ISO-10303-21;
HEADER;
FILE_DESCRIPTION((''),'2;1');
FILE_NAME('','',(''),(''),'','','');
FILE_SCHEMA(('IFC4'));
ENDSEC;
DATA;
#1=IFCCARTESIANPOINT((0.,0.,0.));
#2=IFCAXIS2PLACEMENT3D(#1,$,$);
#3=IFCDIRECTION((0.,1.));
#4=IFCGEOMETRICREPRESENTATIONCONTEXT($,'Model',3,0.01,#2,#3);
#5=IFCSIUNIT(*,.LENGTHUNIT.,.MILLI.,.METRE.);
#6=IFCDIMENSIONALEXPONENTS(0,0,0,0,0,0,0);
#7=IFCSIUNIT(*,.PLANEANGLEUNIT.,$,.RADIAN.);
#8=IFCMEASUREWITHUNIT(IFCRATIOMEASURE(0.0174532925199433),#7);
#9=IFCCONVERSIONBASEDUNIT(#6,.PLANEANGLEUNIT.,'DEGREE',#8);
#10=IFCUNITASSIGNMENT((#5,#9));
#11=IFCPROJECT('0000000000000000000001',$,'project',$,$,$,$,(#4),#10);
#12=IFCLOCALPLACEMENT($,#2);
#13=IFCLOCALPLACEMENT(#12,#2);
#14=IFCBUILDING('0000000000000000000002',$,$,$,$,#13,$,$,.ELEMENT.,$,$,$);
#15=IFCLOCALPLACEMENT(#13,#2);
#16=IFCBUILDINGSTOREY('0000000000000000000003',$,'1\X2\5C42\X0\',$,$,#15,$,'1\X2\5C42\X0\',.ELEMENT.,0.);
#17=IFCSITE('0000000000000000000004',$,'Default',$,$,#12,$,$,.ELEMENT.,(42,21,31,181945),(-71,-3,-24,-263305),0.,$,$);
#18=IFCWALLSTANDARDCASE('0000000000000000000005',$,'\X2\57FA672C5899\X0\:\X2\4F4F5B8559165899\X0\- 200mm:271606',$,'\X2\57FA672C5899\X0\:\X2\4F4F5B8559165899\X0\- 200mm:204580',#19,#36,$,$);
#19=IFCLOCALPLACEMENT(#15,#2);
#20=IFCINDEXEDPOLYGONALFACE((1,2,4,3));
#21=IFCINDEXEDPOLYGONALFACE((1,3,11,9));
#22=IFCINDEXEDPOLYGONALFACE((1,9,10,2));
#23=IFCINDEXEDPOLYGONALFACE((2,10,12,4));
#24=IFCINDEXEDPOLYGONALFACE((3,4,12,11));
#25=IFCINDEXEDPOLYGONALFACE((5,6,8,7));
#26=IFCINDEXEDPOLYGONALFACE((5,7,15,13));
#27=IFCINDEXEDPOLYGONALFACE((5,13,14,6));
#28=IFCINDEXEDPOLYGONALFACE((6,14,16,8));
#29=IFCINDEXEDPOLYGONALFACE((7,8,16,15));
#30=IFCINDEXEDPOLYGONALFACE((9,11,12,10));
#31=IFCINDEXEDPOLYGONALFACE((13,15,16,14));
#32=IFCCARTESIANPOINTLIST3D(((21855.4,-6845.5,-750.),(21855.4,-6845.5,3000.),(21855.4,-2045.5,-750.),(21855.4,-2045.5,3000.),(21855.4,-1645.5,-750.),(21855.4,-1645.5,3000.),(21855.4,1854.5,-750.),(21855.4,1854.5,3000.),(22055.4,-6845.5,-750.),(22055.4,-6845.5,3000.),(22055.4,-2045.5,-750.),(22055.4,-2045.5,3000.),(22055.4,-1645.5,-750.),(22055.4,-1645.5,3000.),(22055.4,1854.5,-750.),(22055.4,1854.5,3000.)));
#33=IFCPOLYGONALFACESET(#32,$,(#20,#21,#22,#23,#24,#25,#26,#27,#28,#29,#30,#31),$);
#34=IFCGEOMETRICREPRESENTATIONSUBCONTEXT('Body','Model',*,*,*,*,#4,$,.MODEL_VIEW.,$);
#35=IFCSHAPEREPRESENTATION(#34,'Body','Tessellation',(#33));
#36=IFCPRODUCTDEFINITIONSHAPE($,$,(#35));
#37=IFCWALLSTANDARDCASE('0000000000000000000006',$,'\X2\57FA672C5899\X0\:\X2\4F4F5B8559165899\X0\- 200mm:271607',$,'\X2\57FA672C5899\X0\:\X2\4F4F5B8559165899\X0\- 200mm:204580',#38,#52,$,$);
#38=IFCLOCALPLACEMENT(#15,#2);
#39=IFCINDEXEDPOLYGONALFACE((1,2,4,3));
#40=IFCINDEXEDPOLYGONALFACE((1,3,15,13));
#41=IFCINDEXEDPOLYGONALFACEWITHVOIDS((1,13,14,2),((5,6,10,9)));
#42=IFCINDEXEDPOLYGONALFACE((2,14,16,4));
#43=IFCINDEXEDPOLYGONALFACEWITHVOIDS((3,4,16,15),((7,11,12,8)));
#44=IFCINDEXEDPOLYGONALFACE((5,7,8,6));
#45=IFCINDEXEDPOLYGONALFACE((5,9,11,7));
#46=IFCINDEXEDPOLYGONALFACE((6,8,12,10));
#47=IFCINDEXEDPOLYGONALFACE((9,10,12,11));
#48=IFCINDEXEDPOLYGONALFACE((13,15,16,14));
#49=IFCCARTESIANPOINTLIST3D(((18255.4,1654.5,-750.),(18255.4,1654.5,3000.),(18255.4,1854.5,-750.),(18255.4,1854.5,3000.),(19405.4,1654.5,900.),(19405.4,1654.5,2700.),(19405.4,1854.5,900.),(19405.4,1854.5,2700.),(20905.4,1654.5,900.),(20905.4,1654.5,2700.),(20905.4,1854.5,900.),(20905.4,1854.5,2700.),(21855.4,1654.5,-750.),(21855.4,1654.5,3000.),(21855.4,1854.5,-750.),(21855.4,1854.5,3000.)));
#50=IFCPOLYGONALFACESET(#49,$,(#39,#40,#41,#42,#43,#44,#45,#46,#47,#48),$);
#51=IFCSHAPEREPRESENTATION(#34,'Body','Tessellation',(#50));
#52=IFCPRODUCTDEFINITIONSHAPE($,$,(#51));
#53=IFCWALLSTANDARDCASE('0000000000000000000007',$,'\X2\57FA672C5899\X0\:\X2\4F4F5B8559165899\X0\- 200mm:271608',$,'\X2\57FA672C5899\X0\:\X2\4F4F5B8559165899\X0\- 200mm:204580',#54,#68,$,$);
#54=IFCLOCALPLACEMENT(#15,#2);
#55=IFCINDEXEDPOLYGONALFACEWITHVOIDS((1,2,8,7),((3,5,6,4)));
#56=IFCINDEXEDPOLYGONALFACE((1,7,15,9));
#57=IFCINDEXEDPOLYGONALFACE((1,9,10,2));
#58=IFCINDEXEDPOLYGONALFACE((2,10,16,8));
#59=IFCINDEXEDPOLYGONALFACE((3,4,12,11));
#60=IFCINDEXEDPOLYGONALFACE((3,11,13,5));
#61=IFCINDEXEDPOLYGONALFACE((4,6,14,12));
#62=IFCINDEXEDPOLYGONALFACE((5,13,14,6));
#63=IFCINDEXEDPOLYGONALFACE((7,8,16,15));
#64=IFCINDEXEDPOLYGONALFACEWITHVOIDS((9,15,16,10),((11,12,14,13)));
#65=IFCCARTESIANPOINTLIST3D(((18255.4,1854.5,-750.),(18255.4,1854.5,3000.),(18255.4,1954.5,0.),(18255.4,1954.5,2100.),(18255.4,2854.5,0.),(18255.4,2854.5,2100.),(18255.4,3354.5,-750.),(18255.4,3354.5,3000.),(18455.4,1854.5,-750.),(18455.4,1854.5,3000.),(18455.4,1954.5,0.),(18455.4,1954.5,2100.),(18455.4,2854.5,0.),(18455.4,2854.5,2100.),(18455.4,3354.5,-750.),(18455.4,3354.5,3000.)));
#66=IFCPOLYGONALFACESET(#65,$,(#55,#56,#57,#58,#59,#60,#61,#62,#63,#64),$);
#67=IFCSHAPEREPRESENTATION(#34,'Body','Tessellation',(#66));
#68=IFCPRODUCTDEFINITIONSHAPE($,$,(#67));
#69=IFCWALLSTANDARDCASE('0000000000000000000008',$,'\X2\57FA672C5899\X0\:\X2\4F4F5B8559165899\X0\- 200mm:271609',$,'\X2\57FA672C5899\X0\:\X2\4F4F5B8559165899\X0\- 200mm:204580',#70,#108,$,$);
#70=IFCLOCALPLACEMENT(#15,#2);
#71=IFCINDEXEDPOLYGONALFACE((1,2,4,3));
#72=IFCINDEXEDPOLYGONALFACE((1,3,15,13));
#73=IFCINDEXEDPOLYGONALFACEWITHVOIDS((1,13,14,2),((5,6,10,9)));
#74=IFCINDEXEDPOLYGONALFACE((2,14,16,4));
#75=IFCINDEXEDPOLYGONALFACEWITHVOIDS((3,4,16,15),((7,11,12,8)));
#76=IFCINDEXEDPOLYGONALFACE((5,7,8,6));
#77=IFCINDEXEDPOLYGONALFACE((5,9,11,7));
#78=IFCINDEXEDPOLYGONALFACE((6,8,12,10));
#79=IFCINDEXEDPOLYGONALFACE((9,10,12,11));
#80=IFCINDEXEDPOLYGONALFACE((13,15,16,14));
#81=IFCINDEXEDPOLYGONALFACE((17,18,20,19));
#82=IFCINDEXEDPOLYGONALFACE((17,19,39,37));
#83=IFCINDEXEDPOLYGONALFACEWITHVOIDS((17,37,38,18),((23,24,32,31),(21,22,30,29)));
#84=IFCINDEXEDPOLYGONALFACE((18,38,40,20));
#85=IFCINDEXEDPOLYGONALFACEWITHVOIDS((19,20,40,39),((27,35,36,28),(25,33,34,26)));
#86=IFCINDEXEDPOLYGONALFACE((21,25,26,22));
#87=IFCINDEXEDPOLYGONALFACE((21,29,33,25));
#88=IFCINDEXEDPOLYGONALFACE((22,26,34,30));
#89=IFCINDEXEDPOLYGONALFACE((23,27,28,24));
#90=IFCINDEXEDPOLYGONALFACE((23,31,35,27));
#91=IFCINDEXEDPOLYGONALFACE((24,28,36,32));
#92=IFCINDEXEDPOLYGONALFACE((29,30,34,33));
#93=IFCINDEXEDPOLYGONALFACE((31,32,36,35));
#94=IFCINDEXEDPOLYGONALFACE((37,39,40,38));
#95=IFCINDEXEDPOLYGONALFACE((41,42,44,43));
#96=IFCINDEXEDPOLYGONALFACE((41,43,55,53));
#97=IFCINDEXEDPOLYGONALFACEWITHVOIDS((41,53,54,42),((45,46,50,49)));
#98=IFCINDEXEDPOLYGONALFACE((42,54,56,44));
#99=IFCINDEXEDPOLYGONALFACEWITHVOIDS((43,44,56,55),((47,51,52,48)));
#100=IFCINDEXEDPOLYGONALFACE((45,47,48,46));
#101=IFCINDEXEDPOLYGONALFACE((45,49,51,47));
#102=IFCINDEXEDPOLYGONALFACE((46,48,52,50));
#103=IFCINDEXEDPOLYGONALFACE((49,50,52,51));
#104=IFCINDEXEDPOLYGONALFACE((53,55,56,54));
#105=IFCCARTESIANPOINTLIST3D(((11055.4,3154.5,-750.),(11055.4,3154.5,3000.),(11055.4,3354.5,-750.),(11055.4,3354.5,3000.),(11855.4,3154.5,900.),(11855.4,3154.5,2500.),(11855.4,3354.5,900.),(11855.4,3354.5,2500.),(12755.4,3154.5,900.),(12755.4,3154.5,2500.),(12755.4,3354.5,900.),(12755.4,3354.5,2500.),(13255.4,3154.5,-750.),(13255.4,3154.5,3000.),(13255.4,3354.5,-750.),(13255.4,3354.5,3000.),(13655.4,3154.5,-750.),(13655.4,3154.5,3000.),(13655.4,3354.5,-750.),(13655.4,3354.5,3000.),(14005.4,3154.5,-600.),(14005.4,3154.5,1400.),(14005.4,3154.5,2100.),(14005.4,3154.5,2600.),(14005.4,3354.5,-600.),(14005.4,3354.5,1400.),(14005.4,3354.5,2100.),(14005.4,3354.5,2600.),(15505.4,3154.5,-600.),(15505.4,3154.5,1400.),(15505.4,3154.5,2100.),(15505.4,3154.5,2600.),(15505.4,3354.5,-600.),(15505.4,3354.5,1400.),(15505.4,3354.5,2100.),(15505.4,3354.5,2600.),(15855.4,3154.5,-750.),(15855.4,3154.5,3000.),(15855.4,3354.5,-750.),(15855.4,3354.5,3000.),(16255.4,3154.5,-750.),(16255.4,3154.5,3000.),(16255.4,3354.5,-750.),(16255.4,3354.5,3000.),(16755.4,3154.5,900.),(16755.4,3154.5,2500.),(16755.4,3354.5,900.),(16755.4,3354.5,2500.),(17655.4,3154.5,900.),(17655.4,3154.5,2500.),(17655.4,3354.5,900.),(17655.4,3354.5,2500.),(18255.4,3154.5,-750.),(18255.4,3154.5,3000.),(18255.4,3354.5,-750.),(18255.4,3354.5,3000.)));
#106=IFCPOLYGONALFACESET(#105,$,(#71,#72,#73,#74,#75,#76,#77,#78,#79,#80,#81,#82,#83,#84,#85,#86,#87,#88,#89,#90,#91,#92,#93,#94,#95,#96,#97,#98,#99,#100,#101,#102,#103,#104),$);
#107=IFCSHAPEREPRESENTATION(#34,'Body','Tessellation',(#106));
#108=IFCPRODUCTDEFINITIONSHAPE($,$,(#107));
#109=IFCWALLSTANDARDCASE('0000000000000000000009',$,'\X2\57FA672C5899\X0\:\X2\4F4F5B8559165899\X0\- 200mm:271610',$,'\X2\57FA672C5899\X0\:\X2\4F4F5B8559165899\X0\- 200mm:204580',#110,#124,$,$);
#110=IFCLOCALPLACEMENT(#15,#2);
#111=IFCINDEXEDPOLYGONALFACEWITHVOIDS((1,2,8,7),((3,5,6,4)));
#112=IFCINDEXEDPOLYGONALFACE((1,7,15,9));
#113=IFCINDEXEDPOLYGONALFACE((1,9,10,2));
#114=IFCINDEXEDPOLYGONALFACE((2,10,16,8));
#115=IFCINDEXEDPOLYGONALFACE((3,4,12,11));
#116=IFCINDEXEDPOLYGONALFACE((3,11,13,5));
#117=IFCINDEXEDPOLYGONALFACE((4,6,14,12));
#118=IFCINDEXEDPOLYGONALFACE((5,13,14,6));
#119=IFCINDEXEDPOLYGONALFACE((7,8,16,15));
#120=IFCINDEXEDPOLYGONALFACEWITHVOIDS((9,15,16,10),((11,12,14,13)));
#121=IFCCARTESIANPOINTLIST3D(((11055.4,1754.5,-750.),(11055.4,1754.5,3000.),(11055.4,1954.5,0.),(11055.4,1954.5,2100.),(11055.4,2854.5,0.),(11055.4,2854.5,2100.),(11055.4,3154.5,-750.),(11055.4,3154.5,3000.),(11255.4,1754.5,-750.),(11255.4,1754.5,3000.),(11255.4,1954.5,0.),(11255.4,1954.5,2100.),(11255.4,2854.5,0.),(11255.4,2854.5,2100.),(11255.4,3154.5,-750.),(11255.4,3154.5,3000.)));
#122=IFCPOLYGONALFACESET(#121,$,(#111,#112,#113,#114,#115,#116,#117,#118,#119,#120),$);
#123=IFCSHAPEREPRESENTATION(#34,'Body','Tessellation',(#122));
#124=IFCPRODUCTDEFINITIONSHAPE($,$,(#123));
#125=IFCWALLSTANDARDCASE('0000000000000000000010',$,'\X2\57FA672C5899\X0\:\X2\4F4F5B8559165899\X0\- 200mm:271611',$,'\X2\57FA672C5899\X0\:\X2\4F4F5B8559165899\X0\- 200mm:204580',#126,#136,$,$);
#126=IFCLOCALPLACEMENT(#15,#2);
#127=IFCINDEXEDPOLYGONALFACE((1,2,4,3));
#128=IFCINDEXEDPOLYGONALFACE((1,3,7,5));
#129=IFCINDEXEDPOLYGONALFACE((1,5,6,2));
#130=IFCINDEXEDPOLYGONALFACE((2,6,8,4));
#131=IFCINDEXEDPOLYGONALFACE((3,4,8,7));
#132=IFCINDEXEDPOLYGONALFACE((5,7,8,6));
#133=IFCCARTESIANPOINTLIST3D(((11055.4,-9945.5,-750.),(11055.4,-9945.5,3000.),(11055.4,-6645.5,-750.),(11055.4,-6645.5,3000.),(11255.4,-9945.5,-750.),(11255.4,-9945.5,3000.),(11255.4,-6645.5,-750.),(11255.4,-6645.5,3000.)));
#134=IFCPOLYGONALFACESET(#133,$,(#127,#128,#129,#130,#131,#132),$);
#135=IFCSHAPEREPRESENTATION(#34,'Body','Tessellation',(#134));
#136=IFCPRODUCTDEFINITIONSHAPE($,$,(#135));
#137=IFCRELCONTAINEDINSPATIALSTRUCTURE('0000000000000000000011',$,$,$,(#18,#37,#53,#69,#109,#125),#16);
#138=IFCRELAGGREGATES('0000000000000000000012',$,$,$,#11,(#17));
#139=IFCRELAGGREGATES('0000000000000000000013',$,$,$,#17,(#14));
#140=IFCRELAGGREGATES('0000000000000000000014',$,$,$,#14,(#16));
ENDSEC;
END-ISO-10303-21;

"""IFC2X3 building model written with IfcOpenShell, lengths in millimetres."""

from ifc_helpers import new_model, entity, si_unit, converted_unit, direction, frame, frame_2d, origin, origin_2d_with_axis, place, context, subcontext, project, spatial, polyline, rectangle, extrude, clip, bounded_halfspace, element, save


model = new_model("IFC2X3")

# Units and contexts
model_context = context("Model", 3, precision=0.01, world=origin(), true_north=direction((0.0, 1.0)))
body_context = subcontext(model_context, "Body", "Model", "MODEL_VIEW")
ifc_project = project(units=[si_unit("LENGTHUNIT", "METRE", prefix="MILLI"), converted_unit("PLANEANGLEUNIT", "DEGREE", entity("IfcRatioMeasure", 0.0174532925199433), si_unit("PLANEANGLEUNIT", "RADIAN"), dimensions=[0, 0, 0, 0, 0, 0, 0])], contexts=[model_context])

# Site, building, storey
site_placement = place(None, origin())
site = spatial("IfcSite", under=ifc_project, at=site_placement, Name="Default", CompositionType="ELEMENT", RefLatitude=(42, 21, 31, 181945), RefLongitude=(-71, -3, -24, -263305), RefElevation=0.0)
building_placement = place(site_placement, origin())
building = spatial("IfcBuilding", under=site, at=building_placement, CompositionType="ELEMENT")
storey_placement = place(building_placement, origin())
storey = spatial("IfcBuildingStorey", under=building, at=storey_placement, Name="1层", LongName="1层", CompositionType="ELEMENT", Elevation=0.0)

# Walls, openings
wall_1_placement = place(storey_placement, frame((21955.4, -6845.5, -750.0), z_axis=(0.0, 0.0, 1.0), x_axis=(0.0, 1.0, 0.0)))
wall_1 = element("IfcWallStandardCase", 1, at=wall_1_placement, inside=storey, Name="基本墙:住宅外墙- 200mm:271606", ObjectType="基本墙:住宅外墙- 200mm:204580", context=body_context, shape_type="SweptSolid", body=[
    extrude(rectangle(XDim=8700.0, YDim=200.0, at=frame_2d((4350.0, 0.0), x_axis=(-1.0, 0.0))), origin(), (0.0, 0.0, 1.0), 3750.0),
])
opening_1_placement = place(storey_placement, frame((21955.4, -6845.5, -750.0), z_axis=(0.0, 0.0, 1.0), x_axis=(0.0, 1.0, 0.0)))
element("IfcOpeningElement", 2, at=opening_1_placement, cuts=wall_1, ObjectType="Opening", context=body_context, shape_type="SweptSolid", body=[
    extrude(rectangle(XDim=3750.0, YDim=200.0, at=origin_2d_with_axis()), frame((4800.0, 0.0, 1875.0), z_axis=(1.0, 0.0, 0.0), x_axis=(0.0, 0.0, -1.0)), (0.0, 0.0, 1.0), 400.0),
])
wall_2_placement = place(storey_placement, frame((21855.4, 1754.5, -750.0), z_axis=(0.0, 0.0, 1.0), x_axis=(-1.0, 0.0, 0.0)))
wall_2 = element("IfcWallStandardCase", 3, at=wall_2_placement, inside=storey, Name="基本墙:住宅外墙- 200mm:271607", ObjectType="基本墙:住宅外墙- 200mm:204580", context=body_context, shape_type="SweptSolid", body=[
    extrude(rectangle(XDim=3600.0, YDim=200.0, at=frame_2d((1800.0, 0.0), x_axis=(-1.0, 0.0))), origin(), (0.0, 0.0, 1.0), 3750.0),
])
opening_2_placement = place(wall_2_placement, frame((950.0, -100.0, 1650.0)))
element("IfcOpeningElement", 4, at=opening_2_placement, cuts=wall_2, ObjectType="Opening", context=body_context, shape_type="SweptSolid", body=[
    extrude(rectangle(XDim=1800.0, YDim=1500.0, at=frame_2d((900.0, 750.0), x_axis=(1.0, 0.0))), frame((0.0, 0.0, 0.0), z_axis=(0.0, 1.0, 0.0), x_axis=(0.0, 0.0, 1.0)), (0.0, 0.0, 1.0), 200.0),
])

# Walls, openings
wall_3_placement = place(storey_placement, frame((18355.4, 1854.5, -750.0), z_axis=(0.0, 0.0, 1.0), x_axis=(0.0, 1.0, 0.0)))
wall_3 = element("IfcWallStandardCase", 5, at=wall_3_placement, inside=storey, Name="基本墙:住宅外墙- 200mm:271608", ObjectType="基本墙:住宅外墙- 200mm:204580", context=body_context, shape_type="SweptSolid", body=[
    extrude(rectangle(XDim=1500.0, YDim=200.0, at=frame_2d((750.0, 0.0), x_axis=(-1.0, 0.0))), origin(), (0.0, 0.0, 1.0), 3750.0),
])
opening_3_placement = place(wall_3_placement, frame((1000.0, 100.0, 750.0)))
element("IfcOpeningElement", 6, at=opening_3_placement, cuts=wall_3, ObjectType="Opening", context=body_context, shape_type="SweptSolid", body=[
    extrude(rectangle(XDim=2100.0, YDim=900.0, at=frame_2d((1050.0, 450.0), x_axis=(1.0, 0.0))), frame((0.0, 0.0, 0.0), z_axis=(0.0, -1.0, 0.0), x_axis=(0.0, 0.0, 1.0)), (0.0, 0.0, 1.0), 200.0),
])
opening_4_placement = place(wall_3_placement, origin())
element("IfcOpeningElement", 7, at=opening_4_placement, cuts=wall_3, ObjectType="Opening", context=body_context, shape_type="SweptSolid", body=[
    extrude(rectangle(XDim=2100.0, YDim=900.0, at=frame_2d((0.0, 0.0), x_axis=(1.0, 0.0))), frame((550.0, -1424.0, 4800.0), z_axis=(0.0, 1.0, 0.0), x_axis=(0.0, 0.0, 1.0)), (0.0, 0.0, 1.0), 3048.0),
])
wall_4_placement = place(storey_placement, frame((18255.4, 3254.5, -750.0), z_axis=(0.0, 0.0, 1.0), x_axis=(-1.0, 0.0, 0.0)))
wall_4 = element("IfcWallStandardCase", 8, at=wall_4_placement, inside=storey, Name="基本墙:住宅外墙- 200mm:271609", ObjectType="基本墙:住宅外墙- 200mm:204580", context=body_context, shape_type="SweptSolid", body=[
    extrude(rectangle(XDim=7200.0, YDim=200.0, at=frame_2d((3600.0, 0.0), x_axis=(-1.0, 0.0))), origin(), (0.0, 0.0, 1.0), 3750.0),
])
opening_5_placement = place(wall_4_placement, frame((4250.0, 100.0, 150.0)))
element("IfcOpeningElement", 9, at=opening_5_placement, cuts=wall_4, ObjectType="Opening", context=body_context, shape_type="SweptSolid", body=[
    extrude(rectangle(XDim=2000.0, YDim=1500.0, at=frame_2d((1000.0, 750.0), x_axis=(1.0, 0.0))), frame((0.0, 0.0, 0.0), z_axis=(0.0, -1.0, 0.0), x_axis=(0.0, 0.0, 1.0)), (0.0, 0.0, 1.0), 200.0),
])
opening_6_placement = place(wall_4_placement, frame((4250.0, 100.0, 2850.0)))
element("IfcOpeningElement", 10, at=opening_6_placement, cuts=wall_4, ObjectType="Opening", context=body_context, shape_type="SweptSolid", body=[
    extrude(rectangle(XDim=500.0, YDim=1500.0, at=frame_2d((250.0, 750.0), x_axis=(1.0, 0.0))), frame((0.0, 0.0, 0.0), z_axis=(0.0, -1.0, 0.0), x_axis=(0.0, 0.0, 1.0)), (0.0, 0.0, 1.0), 200.0),
])
opening_7_placement = place(wall_4_placement, frame((5500.0, -100.0, 1650.0)))
element("IfcOpeningElement", 11, at=opening_7_placement, cuts=wall_4, ObjectType="Opening", context=body_context, shape_type="SweptSolid", body=[
    extrude(rectangle(XDim=1600.0, YDim=900.0, at=frame_2d((800.0, 450.0), x_axis=(1.0, 0.0))), frame((0.0, 0.0, 0.0), z_axis=(0.0, 1.0, 0.0), x_axis=(0.0, 0.0, 1.0)), (0.0, 0.0, 1.0), 200.0),
])
opening_8_placement = place(wall_4_placement, frame((600.0, -100.0, 1650.0)))
element("IfcOpeningElement", 12, at=opening_8_placement, cuts=wall_4, ObjectType="Opening", context=body_context, shape_type="SweptSolid", body=[
    extrude(rectangle(XDim=1600.0, YDim=900.0, at=frame_2d((800.0, 450.0), x_axis=(1.0, 0.0))), frame((0.0, 0.0, 0.0), z_axis=(0.0, 1.0, 0.0), x_axis=(0.0, 0.0, 1.0)), (0.0, 0.0, 1.0), 200.0),
])
opening_9_placement = place(storey_placement, frame((18255.4, 3254.5, -750.0), z_axis=(0.0, 0.0, 1.0), x_axis=(-1.0, 0.0, 0.0)))
element("IfcOpeningElement", 13, at=opening_9_placement, cuts=wall_4, ObjectType="Opening", context=body_context, shape_type="SweptSolid", body=[
    extrude(rectangle(XDim=3750.0, YDim=200.0, at=frame_2d((0.0, 0.0), x_axis=(1.0, 0.0))), frame((5000.0, 0.0, 1875.0), z_axis=(-1.0, 0.0, 0.0), x_axis=(0.0, 0.0, 1.0)), (0.0, 0.0, 1.0), 400.0),
])
opening_10_placement = place(storey_placement, frame((18255.4, 3254.5, -750.0), z_axis=(0.0, 0.0, 1.0), x_axis=(-1.0, 0.0, 0.0)))
element("IfcOpeningElement", 14, at=opening_10_placement, cuts=wall_4, ObjectType="Opening", context=body_context, shape_type="SweptSolid", body=[
    extrude(rectangle(XDim=3750.0, YDim=200.0, at=origin_2d_with_axis()), frame((2400.0, 0.0, 1875.0), z_axis=(-1.0, 0.0, 0.0), x_axis=(0.0, 0.0, 1.0)), (0.0, 0.0, 1.0), 400.0),
])
wall_5_placement = place(storey_placement, frame((11155.4, 3154.5, -750.0), z_axis=(0.0, 0.0, 1.0), x_axis=(0.0, -1.0, 0.0)))
wall_5 = element("IfcWallStandardCase", 15, at=wall_5_placement, inside=storey, Name="基本墙:住宅外墙- 200mm:271610", ObjectType="基本墙:住宅外墙- 200mm:204580", context=body_context, shape_type="SweptSolid", body=[
    extrude(rectangle(XDim=1400.0, YDim=200.0, at=frame_2d((700.0, 0.0), x_axis=(-1.0, 0.0))), origin(), (0.0, 0.0, 1.0), 3750.0),
])
opening_11_placement = place(wall_5_placement, frame((1200.0, 100.0, 750.0)))
element("IfcOpeningElement", 16, at=opening_11_placement, cuts=wall_5, ObjectType="Opening", context=body_context, shape_type="SweptSolid", body=[
    extrude(rectangle(XDim=2100.0, YDim=900.0, at=frame_2d((1050.0, 450.0), x_axis=(1.0, 0.0))), frame((0.0, 0.0, 0.0), z_axis=(0.0, -1.0, 0.0), x_axis=(0.0, 0.0, 1.0)), (0.0, 0.0, 1.0), 200.0),
])
opening_12_placement = place(wall_5_placement, origin())
element("IfcOpeningElement", 17, at=opening_12_placement, cuts=wall_5, ObjectType="Opening", context=body_context, shape_type="SweptSolid", body=[
    extrude(rectangle(XDim=2100.0, YDim=900.0, at=frame_2d((0.0, 0.0), x_axis=(0.0, 1.0))), frame((750.0, -1424.0, 4800.0), z_axis=(0.0, 1.0, 0.0), x_axis=(-1.0, 0.0, 0.0)), (0.0, 0.0, 1.0), 3048.0),
])

# Wall
wall_6_placement = place(storey_placement, frame((11155.4, -6645.5, -750.0), z_axis=(0.0, 0.0, 1.0), x_axis=(0.0, -1.0, 0.0)))
element("IfcWallStandardCase", 18, at=wall_6_placement, inside=storey, Name="基本墙:住宅外墙- 200mm:271611", ObjectType="基本墙:住宅外墙- 200mm:204580", context=body_context, shape_type="Clipping", body=[
    clip(extrude(rectangle(XDim=3300.0, YDim=200.0, at=frame_2d((1650.0, 0.0), x_axis=(-1.0, 0.0))), origin(), (0.0, 0.0, 1.0), 3750.0), bounded_halfspace(frame((3300.0, -100.0, 3750.0), z_axis=(-1.0, 0.0, 0.0), x_axis=(0.0, 0.0, -1.0)), True, frame((3300.0, -100.0, 3750.0), z_axis=(-1.0, 0.0, 0.0), x_axis=(0.0, 0.0, -1.0)), polyline([(0.0, 0.0), (0.0, -200.0), (3750.0, -200.0), (3750.0, 0.0), (0.0, 0.0)]))),
])

save(model, "model.ifc")
